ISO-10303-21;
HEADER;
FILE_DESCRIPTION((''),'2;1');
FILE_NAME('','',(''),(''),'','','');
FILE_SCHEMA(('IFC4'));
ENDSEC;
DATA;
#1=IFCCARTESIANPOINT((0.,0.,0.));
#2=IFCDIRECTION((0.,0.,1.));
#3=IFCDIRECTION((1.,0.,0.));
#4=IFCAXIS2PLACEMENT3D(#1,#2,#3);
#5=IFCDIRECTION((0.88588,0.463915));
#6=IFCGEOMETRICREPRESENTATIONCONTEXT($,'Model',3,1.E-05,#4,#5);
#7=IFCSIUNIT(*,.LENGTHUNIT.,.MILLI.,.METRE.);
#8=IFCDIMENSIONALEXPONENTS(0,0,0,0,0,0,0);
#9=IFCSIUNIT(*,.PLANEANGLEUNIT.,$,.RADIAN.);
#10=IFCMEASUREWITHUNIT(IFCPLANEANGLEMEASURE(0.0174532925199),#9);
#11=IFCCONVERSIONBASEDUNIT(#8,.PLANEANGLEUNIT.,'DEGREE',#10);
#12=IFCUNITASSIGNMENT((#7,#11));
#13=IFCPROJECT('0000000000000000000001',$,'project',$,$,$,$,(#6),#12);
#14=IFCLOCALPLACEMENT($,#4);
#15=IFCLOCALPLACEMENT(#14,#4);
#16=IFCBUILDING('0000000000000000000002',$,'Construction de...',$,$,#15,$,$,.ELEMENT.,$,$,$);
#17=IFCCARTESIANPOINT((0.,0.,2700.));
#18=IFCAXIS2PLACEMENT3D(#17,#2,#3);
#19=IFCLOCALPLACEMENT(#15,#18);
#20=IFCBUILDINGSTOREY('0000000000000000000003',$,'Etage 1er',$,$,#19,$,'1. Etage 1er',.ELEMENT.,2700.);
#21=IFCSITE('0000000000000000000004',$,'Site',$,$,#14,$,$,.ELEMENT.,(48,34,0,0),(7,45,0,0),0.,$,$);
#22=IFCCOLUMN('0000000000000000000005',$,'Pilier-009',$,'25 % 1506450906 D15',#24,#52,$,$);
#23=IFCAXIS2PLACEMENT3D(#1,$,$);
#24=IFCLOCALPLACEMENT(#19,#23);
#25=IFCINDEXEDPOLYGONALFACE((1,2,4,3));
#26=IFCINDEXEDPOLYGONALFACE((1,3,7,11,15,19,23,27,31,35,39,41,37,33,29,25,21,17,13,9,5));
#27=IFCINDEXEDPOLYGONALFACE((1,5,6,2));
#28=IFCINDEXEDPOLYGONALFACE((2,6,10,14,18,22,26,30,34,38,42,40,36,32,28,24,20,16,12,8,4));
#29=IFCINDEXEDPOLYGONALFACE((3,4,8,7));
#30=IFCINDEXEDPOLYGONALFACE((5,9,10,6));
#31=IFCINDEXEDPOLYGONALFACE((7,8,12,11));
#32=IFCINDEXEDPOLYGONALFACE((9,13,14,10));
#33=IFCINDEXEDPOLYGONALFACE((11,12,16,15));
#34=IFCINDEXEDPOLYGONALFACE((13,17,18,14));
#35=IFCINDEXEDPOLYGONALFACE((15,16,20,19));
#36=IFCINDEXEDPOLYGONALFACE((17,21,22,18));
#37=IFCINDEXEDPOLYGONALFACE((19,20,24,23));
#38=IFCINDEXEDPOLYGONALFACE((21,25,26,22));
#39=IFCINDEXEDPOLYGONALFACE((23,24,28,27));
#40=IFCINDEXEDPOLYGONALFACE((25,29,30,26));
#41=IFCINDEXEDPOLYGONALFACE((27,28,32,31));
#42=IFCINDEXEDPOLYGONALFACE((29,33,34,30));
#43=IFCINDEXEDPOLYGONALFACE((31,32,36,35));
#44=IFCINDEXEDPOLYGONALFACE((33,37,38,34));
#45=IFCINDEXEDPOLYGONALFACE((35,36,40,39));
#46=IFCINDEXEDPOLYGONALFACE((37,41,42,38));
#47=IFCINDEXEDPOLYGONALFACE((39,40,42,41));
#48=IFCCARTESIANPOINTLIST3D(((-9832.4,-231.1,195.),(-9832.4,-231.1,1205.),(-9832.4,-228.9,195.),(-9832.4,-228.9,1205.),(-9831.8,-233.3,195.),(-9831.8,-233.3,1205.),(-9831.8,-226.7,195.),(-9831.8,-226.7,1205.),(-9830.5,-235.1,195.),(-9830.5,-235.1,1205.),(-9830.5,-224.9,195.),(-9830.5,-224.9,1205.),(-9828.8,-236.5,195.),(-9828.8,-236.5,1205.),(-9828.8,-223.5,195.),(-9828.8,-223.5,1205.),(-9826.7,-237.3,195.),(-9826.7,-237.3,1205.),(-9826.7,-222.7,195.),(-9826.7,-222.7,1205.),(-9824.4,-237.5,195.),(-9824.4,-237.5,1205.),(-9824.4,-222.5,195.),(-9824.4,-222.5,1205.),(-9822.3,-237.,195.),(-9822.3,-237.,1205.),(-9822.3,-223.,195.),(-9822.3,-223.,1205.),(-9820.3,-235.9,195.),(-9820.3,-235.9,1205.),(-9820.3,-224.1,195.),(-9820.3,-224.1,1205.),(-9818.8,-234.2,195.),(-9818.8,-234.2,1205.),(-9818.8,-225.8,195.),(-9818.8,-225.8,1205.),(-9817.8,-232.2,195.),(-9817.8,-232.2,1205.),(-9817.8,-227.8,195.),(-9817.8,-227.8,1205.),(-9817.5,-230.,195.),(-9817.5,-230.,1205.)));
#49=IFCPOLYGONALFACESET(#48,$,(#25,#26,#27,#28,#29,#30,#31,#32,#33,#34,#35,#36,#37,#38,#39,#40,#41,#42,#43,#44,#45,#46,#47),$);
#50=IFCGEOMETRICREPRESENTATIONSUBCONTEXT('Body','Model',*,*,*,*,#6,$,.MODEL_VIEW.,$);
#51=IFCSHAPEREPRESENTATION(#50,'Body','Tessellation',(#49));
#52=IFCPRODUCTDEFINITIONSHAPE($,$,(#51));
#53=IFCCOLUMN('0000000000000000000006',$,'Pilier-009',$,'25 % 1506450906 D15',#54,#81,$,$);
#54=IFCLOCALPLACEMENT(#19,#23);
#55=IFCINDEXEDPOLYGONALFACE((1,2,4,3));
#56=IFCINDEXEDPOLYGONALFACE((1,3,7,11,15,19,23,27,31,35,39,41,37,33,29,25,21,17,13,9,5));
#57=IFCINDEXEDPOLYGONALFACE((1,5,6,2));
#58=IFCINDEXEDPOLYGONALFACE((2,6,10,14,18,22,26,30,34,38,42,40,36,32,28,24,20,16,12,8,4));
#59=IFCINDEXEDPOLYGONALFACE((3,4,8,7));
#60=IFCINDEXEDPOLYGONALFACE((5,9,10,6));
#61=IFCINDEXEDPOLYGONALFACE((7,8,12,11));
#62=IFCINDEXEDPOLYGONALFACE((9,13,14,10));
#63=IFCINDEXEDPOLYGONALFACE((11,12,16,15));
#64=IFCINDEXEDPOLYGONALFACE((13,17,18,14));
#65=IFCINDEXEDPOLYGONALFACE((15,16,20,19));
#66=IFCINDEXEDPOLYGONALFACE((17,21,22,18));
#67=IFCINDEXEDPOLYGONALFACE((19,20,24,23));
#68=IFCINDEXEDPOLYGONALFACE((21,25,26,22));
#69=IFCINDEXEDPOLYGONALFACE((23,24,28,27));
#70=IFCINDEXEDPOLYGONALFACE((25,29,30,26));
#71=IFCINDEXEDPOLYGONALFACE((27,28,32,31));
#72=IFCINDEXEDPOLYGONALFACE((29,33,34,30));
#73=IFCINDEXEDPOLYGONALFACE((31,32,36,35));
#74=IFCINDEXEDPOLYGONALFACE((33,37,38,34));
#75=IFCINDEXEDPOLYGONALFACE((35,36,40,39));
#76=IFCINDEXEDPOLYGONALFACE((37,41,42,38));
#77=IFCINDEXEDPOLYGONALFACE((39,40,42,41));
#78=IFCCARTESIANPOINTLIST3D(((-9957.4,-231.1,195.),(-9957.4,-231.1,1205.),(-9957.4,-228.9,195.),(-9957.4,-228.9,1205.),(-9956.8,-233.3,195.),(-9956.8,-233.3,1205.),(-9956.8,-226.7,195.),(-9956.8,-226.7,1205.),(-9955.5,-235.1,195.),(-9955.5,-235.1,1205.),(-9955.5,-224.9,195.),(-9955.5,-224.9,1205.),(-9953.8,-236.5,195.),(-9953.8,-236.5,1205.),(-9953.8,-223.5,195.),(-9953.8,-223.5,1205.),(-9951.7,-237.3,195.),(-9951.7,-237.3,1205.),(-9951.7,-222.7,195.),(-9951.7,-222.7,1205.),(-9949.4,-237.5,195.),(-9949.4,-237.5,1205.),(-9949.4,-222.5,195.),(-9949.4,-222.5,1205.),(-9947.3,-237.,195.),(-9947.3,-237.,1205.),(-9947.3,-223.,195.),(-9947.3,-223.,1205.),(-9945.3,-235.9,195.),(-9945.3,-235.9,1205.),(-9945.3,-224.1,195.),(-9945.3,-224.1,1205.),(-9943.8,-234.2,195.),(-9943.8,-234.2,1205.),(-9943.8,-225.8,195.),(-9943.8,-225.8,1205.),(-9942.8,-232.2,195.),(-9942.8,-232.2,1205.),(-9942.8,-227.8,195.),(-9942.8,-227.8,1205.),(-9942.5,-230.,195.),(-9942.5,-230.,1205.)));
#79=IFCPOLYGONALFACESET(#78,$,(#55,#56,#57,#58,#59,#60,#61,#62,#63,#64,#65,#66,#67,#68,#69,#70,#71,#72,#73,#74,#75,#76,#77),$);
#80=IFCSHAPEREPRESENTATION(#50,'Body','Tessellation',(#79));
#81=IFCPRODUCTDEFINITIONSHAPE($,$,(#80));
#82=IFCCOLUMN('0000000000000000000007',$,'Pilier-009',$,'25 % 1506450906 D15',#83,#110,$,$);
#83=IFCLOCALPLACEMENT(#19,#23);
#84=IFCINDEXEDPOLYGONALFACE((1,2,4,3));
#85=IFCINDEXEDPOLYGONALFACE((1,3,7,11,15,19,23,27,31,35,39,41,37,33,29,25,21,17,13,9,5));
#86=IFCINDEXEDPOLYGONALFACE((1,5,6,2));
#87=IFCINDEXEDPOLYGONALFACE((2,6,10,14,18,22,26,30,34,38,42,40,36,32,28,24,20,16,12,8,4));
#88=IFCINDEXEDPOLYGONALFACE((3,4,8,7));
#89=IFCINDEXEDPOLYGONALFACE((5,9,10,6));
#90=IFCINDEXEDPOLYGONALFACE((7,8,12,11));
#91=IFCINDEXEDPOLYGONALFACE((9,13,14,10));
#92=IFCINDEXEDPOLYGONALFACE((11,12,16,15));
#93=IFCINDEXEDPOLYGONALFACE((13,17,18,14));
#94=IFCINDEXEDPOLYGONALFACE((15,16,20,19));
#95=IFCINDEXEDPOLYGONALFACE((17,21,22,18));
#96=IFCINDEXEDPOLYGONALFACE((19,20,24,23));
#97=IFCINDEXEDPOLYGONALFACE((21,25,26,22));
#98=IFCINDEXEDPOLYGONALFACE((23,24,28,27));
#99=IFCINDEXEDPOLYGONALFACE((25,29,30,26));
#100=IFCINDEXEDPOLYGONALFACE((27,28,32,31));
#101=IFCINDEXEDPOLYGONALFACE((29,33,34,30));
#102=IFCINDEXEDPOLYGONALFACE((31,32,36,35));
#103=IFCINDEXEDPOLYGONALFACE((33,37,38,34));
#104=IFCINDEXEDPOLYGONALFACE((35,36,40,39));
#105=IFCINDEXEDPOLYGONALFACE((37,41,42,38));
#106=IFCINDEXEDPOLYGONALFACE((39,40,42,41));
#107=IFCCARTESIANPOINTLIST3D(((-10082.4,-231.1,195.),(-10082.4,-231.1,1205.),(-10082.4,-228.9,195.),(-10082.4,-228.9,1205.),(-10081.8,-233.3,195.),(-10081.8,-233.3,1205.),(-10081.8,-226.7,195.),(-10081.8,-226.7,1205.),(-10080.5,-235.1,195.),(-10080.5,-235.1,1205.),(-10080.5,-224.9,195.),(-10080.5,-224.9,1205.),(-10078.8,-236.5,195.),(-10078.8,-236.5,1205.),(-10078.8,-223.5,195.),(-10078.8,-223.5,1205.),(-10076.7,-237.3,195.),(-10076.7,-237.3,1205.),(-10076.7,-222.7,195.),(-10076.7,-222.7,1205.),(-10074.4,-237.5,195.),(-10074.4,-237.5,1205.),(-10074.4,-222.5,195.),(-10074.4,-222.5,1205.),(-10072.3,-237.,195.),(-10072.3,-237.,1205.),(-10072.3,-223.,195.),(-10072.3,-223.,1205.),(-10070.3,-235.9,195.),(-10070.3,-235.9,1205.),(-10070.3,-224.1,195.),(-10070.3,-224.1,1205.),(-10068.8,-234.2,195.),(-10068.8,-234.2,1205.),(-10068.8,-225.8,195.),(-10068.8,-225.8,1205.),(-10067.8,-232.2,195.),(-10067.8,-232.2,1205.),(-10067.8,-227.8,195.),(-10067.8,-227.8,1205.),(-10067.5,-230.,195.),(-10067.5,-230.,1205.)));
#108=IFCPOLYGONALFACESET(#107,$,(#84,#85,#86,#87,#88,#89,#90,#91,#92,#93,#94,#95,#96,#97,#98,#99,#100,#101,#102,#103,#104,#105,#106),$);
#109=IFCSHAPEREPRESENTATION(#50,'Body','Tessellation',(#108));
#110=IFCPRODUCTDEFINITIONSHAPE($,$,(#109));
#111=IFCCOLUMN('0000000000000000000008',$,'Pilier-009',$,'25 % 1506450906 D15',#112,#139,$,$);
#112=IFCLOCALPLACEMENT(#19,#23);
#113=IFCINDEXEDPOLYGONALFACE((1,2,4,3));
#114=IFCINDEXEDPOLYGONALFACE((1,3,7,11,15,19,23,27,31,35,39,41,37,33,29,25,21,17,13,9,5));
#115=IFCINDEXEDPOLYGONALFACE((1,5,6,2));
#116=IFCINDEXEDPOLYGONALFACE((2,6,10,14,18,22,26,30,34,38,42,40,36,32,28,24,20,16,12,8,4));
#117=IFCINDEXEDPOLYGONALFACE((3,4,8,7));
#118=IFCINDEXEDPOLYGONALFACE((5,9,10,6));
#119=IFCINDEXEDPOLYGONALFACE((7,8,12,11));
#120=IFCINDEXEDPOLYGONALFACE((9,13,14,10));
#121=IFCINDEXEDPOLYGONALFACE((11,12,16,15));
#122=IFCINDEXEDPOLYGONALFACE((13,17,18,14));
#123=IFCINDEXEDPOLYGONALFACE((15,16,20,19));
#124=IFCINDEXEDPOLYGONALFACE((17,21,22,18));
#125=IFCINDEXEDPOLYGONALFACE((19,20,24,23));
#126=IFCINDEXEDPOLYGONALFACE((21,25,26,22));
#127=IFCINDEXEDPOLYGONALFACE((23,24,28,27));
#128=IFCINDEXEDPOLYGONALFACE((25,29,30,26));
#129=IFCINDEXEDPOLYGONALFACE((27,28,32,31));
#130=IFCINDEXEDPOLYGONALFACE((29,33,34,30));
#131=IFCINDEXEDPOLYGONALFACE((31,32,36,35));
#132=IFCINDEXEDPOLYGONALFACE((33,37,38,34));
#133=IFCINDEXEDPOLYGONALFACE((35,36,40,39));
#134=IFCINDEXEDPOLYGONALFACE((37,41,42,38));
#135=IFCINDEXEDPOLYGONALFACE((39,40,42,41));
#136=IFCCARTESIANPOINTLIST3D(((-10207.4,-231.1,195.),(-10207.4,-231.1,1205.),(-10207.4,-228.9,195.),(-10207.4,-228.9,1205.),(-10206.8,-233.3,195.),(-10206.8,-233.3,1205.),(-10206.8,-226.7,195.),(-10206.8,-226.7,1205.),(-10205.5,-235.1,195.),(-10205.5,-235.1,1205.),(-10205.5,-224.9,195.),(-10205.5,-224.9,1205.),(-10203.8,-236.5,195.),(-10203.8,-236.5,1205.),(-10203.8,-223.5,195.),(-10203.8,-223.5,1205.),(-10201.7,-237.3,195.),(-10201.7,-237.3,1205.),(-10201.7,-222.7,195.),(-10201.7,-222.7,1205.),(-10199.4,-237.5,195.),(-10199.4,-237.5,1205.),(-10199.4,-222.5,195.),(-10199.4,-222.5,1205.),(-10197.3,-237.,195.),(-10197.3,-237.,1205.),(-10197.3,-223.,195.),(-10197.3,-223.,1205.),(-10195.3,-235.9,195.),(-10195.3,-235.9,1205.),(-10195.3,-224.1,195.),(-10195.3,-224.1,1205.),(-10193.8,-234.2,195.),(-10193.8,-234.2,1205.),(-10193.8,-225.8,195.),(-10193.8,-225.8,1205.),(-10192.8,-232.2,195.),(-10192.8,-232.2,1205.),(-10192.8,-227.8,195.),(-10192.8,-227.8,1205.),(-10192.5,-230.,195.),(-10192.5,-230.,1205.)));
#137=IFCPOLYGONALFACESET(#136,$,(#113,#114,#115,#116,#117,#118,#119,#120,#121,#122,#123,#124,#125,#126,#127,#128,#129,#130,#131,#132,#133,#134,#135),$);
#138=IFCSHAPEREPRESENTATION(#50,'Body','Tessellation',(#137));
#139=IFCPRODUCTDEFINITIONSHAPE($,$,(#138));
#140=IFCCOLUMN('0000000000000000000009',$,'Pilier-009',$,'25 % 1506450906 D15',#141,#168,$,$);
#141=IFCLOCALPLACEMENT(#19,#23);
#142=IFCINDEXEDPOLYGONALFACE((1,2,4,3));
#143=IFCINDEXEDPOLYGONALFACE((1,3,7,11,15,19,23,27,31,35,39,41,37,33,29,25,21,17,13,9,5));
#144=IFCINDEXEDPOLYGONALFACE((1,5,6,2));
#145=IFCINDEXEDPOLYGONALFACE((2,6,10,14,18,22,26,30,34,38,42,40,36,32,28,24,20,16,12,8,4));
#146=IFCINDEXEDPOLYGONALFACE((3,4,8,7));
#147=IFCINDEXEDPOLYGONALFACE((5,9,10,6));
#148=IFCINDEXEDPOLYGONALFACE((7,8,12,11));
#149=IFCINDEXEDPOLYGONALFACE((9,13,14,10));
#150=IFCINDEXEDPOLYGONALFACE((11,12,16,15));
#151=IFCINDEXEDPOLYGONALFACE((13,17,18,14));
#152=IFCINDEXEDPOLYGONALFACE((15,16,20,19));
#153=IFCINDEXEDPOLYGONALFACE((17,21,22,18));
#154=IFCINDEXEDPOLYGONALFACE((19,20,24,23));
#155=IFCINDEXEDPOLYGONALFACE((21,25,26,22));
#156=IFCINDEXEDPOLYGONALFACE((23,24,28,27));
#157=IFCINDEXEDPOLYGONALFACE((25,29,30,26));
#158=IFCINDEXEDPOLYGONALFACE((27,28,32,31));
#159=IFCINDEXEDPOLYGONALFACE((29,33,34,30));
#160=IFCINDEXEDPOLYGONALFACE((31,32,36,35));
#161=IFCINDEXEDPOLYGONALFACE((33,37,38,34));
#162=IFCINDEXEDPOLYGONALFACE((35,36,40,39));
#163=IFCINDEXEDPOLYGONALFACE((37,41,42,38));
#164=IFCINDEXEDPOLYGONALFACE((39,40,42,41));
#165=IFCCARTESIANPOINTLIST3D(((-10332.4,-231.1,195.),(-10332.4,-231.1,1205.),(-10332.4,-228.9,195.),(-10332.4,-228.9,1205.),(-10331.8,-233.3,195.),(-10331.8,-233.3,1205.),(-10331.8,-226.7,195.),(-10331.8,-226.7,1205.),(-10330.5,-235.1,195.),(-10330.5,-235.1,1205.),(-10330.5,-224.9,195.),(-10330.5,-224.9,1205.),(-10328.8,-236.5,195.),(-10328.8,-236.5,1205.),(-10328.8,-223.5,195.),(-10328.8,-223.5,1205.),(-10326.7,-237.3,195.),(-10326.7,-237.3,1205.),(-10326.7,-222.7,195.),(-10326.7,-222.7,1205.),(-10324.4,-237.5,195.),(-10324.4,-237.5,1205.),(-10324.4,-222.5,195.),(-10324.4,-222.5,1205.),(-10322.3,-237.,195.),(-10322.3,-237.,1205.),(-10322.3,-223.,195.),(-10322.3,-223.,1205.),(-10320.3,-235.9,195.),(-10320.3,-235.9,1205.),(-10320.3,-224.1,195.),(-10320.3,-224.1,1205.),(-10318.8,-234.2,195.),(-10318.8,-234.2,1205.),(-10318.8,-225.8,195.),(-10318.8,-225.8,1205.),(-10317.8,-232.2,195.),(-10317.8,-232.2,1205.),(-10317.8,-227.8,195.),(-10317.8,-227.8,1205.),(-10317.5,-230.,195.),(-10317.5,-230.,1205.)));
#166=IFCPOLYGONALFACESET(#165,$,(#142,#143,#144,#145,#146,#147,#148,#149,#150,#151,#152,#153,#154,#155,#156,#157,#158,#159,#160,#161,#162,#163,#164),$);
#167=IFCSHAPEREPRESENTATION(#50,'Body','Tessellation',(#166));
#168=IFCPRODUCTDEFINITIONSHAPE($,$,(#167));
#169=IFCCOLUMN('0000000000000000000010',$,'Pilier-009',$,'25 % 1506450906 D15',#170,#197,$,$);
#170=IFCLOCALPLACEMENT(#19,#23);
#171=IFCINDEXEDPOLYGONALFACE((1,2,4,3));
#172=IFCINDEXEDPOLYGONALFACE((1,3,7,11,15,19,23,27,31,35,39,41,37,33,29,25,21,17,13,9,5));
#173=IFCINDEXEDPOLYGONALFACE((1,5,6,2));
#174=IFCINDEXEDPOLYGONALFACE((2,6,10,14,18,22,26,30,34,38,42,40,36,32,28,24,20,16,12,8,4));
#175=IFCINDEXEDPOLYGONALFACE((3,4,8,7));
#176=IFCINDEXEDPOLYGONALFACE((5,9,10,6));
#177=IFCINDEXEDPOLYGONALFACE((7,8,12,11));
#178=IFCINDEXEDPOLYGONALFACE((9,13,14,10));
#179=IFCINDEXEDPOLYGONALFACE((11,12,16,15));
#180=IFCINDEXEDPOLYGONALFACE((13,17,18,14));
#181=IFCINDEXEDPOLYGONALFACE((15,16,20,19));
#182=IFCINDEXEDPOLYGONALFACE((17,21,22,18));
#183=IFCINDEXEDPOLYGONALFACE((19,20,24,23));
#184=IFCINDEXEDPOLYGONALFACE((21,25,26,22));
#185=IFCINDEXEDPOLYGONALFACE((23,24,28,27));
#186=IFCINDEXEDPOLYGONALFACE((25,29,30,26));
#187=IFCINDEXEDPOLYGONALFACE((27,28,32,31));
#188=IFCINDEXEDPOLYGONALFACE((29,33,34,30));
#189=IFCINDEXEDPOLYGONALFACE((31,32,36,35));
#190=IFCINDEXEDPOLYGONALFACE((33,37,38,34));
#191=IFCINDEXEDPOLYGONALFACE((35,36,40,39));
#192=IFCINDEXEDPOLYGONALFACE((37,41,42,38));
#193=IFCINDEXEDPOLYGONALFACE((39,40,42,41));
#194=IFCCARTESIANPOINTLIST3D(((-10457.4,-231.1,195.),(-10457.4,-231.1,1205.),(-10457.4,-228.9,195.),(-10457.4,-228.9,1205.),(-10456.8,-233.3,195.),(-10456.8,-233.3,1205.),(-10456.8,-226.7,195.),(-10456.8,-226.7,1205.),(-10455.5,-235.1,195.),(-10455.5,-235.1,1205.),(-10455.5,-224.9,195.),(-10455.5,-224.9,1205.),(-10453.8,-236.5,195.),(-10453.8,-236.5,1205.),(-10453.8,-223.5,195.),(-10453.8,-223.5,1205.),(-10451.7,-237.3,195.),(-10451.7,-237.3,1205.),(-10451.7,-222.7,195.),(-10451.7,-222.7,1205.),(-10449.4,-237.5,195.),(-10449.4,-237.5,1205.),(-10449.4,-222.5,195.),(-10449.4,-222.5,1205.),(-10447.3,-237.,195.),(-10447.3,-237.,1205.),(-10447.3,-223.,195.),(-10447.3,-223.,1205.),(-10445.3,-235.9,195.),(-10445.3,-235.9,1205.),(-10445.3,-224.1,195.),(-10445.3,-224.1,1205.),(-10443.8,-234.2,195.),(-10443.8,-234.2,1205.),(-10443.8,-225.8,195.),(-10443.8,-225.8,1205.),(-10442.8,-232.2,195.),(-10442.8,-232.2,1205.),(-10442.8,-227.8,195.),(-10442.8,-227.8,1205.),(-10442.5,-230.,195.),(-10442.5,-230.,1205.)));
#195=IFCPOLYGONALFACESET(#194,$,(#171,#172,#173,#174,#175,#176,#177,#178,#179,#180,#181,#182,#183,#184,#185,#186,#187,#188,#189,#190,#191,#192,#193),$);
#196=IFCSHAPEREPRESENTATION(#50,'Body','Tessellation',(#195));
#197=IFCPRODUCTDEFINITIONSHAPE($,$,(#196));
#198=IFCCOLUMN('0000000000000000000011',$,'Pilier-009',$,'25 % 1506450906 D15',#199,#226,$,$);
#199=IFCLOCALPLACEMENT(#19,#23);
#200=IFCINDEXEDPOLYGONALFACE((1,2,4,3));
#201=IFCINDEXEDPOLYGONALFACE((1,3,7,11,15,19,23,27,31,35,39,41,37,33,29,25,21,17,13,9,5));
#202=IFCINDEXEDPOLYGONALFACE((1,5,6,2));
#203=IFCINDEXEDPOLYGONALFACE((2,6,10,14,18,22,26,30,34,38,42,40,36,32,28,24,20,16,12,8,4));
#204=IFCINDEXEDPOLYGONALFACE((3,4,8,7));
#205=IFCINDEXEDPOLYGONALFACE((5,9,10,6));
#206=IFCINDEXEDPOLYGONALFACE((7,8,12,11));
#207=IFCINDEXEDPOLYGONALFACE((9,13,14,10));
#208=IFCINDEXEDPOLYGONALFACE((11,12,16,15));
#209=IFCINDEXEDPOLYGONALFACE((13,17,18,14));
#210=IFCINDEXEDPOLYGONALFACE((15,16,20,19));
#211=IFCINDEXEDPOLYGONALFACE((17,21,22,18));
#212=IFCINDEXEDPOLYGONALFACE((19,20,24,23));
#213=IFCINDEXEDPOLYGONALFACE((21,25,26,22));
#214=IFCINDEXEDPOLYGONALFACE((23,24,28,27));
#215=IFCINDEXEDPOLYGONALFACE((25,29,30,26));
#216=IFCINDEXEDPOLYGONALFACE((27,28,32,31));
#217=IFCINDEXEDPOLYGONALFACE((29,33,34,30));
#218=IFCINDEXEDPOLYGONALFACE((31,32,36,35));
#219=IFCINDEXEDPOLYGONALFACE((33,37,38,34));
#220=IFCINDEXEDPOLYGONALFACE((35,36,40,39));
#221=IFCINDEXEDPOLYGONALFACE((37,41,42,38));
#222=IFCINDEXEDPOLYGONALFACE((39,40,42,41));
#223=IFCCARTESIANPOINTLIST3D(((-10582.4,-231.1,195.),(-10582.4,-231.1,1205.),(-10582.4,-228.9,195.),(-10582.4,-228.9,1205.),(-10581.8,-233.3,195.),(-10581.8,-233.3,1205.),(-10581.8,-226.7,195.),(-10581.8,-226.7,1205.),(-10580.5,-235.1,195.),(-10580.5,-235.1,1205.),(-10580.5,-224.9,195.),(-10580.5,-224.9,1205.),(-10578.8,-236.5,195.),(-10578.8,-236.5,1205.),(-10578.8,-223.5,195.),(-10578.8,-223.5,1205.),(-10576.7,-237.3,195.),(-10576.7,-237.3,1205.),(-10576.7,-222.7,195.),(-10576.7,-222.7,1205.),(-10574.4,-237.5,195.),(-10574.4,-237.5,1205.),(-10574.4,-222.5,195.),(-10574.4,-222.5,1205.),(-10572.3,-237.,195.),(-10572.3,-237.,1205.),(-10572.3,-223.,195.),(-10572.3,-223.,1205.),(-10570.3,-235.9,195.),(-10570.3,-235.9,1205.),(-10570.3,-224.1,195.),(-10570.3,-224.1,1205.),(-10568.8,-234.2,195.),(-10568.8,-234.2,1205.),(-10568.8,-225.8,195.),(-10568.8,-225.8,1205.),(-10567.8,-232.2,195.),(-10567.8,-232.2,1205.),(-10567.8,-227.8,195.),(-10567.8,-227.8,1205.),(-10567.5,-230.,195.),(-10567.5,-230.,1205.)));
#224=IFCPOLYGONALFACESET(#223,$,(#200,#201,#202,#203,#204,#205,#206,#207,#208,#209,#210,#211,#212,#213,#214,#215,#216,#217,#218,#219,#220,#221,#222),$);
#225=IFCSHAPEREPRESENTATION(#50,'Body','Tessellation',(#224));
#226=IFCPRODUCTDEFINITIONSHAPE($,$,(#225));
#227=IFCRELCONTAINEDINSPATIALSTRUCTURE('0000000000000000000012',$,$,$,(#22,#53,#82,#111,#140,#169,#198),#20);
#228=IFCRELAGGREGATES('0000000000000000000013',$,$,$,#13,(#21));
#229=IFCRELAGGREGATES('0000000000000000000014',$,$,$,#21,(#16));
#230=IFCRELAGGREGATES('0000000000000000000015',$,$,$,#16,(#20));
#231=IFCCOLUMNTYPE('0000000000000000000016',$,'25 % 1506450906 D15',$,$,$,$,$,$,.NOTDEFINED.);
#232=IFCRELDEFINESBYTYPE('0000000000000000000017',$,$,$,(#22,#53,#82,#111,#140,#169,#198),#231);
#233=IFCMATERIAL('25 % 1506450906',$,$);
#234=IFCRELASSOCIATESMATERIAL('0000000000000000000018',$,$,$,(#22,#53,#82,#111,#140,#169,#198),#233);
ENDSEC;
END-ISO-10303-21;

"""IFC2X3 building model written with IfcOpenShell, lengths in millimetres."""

from ifc_helpers import new_model, entity, si_unit, converted_unit, direction, frame, origin_with_axes, origin_2d_with_axis, place, context, subcontext, project, spatial, circle, extrude, material, type_object, element, save


model = new_model("IFC2X3")

# Units and contexts
model_context = context("Model", 3, precision=1e-05, world=origin_with_axes(), true_north=direction((0.88588, 0.463915)))
body_context = subcontext(model_context, "Body", "Model", "MODEL_VIEW")
ifc_project = project(units=[si_unit("LENGTHUNIT", "METRE", prefix="MILLI"), converted_unit("PLANEANGLEUNIT", "DEGREE", entity("IfcPlaneAngleMeasure", 0.0174532925199), si_unit("PLANEANGLEUNIT", "RADIAN"), dimensions=[0, 0, 0, 0, 0, 0, 0])], contexts=[model_context])

# Site, building, storey
site_placement = place(None, origin_with_axes())
site = spatial("IfcSite", under=ifc_project, at=site_placement, Name="Site", CompositionType="ELEMENT", RefLatitude=(48, 34, 0, 0), RefLongitude=(7, 45, 0, 0), RefElevation=0.0)
building_placement = place(site_placement, origin_with_axes())
building = spatial("IfcBuilding", under=site, at=building_placement, Name="Construction de...", CompositionType="ELEMENT")
storey_placement = place(building_placement, frame((0.0, 0.0, 2700.0), z_axis=(0.0, 0.0, 1.0), x_axis=(1.0, 0.0, 0.0)))
storey = spatial("IfcBuildingStorey", under=building, at=storey_placement, Name="Etage 1er", LongName="1. Etage 1er", CompositionType="ELEMENT", Elevation=2700.0)

# Columns
ifc_material = material(Name="25 % 1506450906")
column_type = type_object("IfcColumnType", Name="25 % 1506450906 D15", PredefinedType="NOTDEFINED")
for number, where, z_axis, x_axis, name in (
    (1, (-9825.0, -230.0, 195.0), (0.0, 0.0, 1.0), (1.0, 0.0, 0.0), "Pilier-009"),
    (2, (-9950.0, -230.0, 195.0), (0.0, 0.0, 1.0), (1.0, 0.0, 0.0), "Pilier-009"),
    (3, (-10075.0, -230.0, 195.0), (0.0, 0.0, 1.0), (1.0, 0.0, 0.0), "Pilier-009"),
    (4, (-10200.0, -230.0, 195.0), (0.0, 0.0, 1.0), (1.0, 0.0, 0.0), "Pilier-009"),
    (5, (-10325.0, -230.0, 195.0), (0.0, 0.0, 1.0), (1.0, 0.0, 0.0), "Pilier-009"),
    (6, (-10450.0, -230.0, 195.0), (0.0, 0.0, 1.0), (1.0, 0.0, 0.0), "Pilier-009"),
    (7, (-10575.0, -230.0, 195.0), (0.0, 0.0, 1.0), (1.0, 0.0, 0.0), "Pilier-009"),
):
    element("IfcColumn", number, at=place(storey_placement, frame(where, z_axis=z_axis, x_axis=x_axis)), inside=storey, type_object=column_type, material=ifc_material, Name=name, ObjectType="25 % 1506450906 D15", context=body_context, shape_type="SweptSolid", body=[
        extrude(circle(Radius=7.5, at=origin_2d_with_axis()), origin_with_axes(), (0.0, 0.0, 1.0), 1010.0),
    ])

save(model, "model.ifc")
